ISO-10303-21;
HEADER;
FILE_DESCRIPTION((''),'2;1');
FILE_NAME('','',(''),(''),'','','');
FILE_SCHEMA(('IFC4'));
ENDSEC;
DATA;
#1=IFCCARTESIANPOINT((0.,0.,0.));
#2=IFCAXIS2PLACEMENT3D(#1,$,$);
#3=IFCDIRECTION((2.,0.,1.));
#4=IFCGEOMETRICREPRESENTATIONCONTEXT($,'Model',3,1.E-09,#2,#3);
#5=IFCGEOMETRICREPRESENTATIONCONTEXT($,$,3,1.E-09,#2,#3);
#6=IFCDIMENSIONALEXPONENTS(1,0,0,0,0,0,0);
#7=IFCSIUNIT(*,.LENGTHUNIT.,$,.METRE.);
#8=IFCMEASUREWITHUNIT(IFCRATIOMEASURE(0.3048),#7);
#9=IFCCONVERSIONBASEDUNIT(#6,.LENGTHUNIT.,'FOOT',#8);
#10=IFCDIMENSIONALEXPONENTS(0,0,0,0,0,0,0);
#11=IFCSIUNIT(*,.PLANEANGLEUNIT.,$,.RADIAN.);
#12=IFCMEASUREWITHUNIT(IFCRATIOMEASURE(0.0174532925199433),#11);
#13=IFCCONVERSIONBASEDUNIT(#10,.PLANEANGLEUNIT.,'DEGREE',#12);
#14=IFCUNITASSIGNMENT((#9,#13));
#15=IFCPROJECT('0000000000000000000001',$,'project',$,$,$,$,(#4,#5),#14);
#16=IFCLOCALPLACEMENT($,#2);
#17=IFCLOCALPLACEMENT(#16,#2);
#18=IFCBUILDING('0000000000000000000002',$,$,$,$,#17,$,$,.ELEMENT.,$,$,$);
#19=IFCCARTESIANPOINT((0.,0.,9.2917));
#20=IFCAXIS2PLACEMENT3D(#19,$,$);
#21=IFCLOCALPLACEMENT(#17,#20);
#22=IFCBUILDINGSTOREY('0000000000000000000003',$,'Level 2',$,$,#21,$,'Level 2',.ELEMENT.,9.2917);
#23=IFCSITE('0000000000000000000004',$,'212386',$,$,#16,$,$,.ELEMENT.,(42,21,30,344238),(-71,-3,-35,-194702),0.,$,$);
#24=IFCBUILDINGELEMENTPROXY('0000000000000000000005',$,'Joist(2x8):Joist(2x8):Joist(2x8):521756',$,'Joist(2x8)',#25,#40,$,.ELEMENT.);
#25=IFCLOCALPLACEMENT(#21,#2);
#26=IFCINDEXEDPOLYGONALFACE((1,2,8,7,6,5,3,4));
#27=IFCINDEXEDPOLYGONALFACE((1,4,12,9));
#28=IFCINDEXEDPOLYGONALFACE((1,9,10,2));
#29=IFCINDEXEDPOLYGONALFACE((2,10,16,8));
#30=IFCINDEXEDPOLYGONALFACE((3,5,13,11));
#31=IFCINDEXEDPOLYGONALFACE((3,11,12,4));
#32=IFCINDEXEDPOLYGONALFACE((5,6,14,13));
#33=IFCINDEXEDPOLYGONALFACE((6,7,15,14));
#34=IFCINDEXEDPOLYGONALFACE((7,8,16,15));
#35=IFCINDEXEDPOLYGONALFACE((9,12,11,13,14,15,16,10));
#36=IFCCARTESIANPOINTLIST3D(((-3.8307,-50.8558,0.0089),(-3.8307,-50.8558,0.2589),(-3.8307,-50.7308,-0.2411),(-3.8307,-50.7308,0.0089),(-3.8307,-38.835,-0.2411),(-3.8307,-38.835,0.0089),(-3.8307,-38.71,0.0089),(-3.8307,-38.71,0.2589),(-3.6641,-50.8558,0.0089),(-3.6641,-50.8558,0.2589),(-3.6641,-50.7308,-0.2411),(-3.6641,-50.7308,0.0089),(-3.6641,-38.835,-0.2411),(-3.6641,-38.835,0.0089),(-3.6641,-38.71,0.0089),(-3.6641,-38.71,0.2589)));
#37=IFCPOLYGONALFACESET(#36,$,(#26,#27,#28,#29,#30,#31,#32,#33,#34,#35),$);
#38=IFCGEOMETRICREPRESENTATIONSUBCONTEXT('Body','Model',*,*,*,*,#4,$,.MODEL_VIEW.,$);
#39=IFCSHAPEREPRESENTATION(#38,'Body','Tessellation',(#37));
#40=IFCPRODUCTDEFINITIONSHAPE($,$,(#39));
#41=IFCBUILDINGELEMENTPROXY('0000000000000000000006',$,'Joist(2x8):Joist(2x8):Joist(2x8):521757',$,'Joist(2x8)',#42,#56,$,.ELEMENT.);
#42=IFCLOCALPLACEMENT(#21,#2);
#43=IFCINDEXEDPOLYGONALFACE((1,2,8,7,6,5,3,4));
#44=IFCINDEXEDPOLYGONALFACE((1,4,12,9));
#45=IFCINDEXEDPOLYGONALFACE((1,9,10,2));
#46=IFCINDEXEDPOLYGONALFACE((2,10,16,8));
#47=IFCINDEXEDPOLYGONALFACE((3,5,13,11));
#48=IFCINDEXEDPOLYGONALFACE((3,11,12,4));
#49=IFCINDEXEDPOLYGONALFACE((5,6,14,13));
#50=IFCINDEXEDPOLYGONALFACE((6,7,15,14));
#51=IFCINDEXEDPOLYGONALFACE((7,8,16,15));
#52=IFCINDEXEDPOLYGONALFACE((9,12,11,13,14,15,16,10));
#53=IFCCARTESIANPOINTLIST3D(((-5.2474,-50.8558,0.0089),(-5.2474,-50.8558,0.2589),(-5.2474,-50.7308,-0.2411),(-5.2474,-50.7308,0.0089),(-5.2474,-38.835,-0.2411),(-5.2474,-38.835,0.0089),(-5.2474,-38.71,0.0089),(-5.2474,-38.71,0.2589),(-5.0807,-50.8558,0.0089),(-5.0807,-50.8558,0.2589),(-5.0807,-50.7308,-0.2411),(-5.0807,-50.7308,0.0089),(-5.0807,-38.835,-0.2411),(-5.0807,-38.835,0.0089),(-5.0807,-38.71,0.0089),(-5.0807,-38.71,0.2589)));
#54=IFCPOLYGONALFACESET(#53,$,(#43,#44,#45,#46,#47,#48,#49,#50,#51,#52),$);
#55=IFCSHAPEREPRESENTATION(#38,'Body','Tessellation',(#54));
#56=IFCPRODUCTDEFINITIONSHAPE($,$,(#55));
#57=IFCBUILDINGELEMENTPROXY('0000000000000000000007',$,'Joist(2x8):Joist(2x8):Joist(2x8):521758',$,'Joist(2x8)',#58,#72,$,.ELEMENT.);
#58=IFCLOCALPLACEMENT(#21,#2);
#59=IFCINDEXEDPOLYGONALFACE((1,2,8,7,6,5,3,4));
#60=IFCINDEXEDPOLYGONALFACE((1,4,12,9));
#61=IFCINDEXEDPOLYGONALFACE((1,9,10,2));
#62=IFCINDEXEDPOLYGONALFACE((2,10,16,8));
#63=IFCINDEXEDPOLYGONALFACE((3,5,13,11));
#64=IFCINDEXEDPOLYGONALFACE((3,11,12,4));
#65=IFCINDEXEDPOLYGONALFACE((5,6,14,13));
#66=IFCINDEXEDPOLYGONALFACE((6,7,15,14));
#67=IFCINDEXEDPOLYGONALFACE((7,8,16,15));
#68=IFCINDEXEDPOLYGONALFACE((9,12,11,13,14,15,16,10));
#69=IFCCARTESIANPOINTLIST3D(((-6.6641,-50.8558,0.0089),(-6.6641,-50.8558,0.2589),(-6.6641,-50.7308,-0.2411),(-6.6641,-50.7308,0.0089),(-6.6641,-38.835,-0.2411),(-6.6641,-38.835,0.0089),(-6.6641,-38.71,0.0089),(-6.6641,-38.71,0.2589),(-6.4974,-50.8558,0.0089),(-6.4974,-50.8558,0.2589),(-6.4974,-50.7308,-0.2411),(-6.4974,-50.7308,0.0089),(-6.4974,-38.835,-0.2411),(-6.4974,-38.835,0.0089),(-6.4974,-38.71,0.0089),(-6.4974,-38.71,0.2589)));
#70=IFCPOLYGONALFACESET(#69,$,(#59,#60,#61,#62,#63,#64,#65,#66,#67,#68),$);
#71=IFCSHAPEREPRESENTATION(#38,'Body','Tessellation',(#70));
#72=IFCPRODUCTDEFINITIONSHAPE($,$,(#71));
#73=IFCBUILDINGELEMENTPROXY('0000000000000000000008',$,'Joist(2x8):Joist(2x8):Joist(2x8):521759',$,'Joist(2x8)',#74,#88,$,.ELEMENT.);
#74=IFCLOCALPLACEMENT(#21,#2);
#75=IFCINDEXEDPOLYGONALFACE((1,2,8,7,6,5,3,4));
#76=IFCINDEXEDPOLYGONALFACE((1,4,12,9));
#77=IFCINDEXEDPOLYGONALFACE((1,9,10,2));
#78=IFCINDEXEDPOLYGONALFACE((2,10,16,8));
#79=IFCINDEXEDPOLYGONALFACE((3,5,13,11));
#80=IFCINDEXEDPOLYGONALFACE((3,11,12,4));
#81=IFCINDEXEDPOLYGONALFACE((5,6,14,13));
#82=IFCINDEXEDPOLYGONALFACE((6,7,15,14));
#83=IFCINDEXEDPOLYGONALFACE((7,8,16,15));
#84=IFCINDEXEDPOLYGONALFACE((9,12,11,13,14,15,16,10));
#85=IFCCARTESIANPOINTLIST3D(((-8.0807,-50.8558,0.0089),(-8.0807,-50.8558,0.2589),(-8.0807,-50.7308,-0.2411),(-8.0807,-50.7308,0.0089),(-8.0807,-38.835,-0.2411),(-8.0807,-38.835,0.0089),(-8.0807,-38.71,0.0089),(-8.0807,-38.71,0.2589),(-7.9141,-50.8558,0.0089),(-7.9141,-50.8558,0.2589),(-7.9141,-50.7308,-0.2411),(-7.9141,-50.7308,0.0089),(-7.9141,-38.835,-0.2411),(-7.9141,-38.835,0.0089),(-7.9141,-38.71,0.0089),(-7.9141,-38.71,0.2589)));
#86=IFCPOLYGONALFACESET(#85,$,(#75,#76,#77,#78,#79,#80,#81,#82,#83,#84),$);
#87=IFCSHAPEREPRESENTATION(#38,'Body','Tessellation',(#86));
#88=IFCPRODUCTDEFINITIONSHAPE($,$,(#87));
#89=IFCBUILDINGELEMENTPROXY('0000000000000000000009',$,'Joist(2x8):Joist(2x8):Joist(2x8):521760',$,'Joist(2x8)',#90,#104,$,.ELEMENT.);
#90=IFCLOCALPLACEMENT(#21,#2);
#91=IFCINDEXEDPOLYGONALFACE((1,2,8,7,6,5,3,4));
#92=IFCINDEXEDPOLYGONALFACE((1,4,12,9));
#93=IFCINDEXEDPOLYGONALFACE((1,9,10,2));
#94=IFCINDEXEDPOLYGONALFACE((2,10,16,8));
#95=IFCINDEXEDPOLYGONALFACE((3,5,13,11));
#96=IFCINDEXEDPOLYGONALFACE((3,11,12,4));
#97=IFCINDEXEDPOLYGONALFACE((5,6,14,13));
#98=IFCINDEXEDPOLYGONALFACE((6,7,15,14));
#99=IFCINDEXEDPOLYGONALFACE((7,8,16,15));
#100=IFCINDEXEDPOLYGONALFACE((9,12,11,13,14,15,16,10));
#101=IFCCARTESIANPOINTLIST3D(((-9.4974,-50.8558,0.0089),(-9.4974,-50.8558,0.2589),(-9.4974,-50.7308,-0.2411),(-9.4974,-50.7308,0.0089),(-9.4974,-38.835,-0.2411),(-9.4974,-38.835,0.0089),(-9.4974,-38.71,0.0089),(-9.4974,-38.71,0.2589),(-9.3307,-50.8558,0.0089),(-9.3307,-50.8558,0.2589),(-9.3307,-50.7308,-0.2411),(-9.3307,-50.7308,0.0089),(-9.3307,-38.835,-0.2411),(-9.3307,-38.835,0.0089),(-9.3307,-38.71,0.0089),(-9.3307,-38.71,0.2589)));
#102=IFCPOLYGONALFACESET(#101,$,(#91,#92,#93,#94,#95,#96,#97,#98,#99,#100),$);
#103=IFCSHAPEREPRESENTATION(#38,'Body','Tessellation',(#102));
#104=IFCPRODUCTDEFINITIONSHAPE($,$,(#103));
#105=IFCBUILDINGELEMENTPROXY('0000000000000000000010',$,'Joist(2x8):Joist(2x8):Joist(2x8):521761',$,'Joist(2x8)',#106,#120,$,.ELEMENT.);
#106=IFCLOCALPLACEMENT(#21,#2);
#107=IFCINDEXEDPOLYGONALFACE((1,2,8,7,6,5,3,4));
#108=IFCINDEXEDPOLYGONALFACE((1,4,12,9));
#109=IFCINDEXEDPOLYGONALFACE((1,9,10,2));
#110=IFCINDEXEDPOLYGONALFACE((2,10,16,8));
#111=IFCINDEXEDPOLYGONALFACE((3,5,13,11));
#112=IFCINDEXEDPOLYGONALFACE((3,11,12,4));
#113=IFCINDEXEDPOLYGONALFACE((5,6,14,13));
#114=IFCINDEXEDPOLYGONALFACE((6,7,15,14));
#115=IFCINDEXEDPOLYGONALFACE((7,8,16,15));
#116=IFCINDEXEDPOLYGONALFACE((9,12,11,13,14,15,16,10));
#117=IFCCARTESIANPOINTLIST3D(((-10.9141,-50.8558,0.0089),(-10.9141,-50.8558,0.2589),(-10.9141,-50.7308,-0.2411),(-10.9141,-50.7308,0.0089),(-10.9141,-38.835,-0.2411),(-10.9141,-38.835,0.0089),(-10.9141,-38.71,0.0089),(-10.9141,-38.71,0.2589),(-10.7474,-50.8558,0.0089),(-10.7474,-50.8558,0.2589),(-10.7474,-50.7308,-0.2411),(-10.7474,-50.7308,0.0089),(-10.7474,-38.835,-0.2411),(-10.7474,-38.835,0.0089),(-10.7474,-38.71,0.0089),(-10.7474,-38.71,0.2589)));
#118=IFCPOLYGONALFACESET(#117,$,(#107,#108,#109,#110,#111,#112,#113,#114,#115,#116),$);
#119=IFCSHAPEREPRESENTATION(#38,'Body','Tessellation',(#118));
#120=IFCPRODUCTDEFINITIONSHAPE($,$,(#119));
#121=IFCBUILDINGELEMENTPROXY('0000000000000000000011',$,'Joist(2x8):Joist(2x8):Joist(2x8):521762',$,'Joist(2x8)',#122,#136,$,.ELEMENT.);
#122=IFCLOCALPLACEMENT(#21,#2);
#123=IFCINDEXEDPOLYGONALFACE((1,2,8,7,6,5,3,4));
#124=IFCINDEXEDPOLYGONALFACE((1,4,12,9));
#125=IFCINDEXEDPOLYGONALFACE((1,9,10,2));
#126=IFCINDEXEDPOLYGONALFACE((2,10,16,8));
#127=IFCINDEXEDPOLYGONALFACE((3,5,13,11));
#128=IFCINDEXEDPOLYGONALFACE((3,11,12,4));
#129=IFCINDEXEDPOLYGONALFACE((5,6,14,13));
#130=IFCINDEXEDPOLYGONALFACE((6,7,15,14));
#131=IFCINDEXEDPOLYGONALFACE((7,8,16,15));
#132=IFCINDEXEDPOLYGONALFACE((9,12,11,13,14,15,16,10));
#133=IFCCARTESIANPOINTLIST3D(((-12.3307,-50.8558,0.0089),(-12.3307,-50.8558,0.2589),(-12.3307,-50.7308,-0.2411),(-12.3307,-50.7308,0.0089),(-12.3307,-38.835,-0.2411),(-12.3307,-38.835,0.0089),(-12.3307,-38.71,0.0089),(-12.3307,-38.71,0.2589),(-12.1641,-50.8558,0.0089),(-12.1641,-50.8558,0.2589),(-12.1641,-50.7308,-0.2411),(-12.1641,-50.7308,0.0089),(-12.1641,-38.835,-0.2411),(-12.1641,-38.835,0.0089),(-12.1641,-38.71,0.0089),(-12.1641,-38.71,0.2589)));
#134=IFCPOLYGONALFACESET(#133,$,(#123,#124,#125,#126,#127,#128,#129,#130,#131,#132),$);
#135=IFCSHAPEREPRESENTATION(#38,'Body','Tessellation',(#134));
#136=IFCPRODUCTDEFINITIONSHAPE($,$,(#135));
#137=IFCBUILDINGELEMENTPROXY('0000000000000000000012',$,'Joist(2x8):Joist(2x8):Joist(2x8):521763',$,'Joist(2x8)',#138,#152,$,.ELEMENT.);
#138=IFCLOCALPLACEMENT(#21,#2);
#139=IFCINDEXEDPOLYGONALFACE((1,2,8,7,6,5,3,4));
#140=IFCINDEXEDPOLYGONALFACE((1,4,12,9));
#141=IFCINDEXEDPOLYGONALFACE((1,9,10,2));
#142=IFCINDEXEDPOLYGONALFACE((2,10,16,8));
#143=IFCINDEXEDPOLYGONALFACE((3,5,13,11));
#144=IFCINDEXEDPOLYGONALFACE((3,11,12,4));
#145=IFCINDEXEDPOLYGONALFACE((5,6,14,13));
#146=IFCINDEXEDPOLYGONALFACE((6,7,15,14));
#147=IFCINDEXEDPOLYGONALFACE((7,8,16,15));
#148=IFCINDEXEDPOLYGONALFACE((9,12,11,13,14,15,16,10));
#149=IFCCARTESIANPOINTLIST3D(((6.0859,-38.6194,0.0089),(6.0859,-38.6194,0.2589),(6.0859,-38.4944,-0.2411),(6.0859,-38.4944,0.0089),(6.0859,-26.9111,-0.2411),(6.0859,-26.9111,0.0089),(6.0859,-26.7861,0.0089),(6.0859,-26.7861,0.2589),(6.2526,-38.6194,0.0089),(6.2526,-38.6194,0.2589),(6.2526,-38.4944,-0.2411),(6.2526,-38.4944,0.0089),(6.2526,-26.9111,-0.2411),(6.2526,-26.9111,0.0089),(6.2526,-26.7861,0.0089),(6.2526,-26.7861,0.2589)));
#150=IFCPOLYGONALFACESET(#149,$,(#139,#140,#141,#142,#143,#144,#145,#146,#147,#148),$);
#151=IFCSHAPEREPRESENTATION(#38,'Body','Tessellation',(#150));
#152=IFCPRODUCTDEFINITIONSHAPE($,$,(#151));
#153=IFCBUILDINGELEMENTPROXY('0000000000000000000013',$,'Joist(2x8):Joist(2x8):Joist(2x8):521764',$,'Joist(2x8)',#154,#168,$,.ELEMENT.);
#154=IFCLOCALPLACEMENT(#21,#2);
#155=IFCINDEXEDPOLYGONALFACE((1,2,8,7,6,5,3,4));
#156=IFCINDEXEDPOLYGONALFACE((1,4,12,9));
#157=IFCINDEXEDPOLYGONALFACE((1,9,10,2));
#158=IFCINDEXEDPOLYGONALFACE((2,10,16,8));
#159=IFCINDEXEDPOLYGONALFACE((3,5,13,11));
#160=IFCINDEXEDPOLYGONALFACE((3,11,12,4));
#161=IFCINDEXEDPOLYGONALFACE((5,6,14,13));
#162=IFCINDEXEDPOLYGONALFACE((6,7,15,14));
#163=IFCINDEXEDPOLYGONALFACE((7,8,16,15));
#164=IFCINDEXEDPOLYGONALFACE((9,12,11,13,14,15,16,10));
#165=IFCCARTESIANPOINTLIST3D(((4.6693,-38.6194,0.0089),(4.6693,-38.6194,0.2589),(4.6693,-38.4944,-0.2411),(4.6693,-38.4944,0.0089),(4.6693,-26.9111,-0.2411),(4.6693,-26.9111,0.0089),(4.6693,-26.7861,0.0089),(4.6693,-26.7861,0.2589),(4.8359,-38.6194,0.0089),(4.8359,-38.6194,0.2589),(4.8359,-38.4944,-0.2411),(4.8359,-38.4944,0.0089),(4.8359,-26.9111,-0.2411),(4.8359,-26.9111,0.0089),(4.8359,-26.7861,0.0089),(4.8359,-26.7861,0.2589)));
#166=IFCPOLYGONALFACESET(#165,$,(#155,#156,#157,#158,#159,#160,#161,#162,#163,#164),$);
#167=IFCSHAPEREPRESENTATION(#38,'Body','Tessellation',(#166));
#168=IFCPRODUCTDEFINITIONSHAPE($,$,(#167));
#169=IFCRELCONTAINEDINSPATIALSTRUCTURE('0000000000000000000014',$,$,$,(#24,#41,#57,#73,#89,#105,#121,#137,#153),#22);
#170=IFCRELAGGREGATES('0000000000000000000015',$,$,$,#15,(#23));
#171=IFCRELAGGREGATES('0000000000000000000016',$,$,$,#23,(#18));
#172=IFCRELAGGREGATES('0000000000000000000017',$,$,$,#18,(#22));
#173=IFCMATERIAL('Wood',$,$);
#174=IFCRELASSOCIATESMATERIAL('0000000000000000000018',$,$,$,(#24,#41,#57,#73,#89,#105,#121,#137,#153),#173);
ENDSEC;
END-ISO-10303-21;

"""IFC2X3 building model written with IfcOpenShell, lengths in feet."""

from ifc_helpers import new_model, entity, si_unit, converted_unit, direction, frame, origin, place, context, subcontext, project, spatial, polyline, outline, extrude, source, transform, mapped, material, element, save


model = new_model("IFC2X3")

# Units and contexts
model_context = context("Model", 3, precision=1e-09, world=origin(), true_north=direction((2.0, 0.0, 1.0)))
context_of_model = context(None, 3, precision=1e-09, world=origin(), true_north=direction((2.0, 0.0, 1.0)))
body_context = subcontext(model_context, "Body", "Model", "MODEL_VIEW")
ifc_project = project(units=[converted_unit("LENGTHUNIT", "FOOT", entity("IfcRatioMeasure", 0.3048), si_unit("LENGTHUNIT", "METRE"), dimensions=[1, 0, 0, 0, 0, 0, 0]), converted_unit("PLANEANGLEUNIT", "DEGREE", entity("IfcRatioMeasure", 0.0174532925199433), si_unit("PLANEANGLEUNIT", "RADIAN"), dimensions=[0, 0, 0, 0, 0, 0, 0])], contexts=[model_context, context_of_model])

# Site, building, storey
site_placement = place(None, origin())
site = spatial("IfcSite", under=ifc_project, at=site_placement, Name="212386", CompositionType="ELEMENT", RefLatitude=(42, 21, 30, 344238), RefLongitude=(-71, -3, -35, -194702), RefElevation=0.0)
building_placement = place(site_placement, origin())
building = spatial("IfcBuilding", under=site, at=building_placement, CompositionType="ELEMENT")
storey_placement = place(building_placement, frame((0.0, 0.0, 9.2917)))
storey = spatial("IfcBuildingStorey", under=building, at=storey_placement, Name="Level 2", LongName="Level 2", CompositionType="ELEMENT", Elevation=9.2917)

# Building element proxies
ifc_material = material(Name="Wood")
shared_shape_1 = source(origin(), body_context, "Body", "SweptSolid", [
    extrude(outline(polyline([(-0.25, -6.0729), (0.0, -6.0729), (0.0, -5.9479), (0.25, -5.9479), (0.25, 5.9479), (0.0, 5.9479), (0.0, 6.0729), (-0.25, 6.0729), (-0.25, -6.0729)])), frame((-3.8307, -44.7829, 9.3006), z_axis=(1.0, 0.0, 0.0), x_axis=(0.0, 0.0, -1.0)), (0.0, 0.0, 1.0), 0.1667),
])
proxy_1_placement = place(storey_placement, frame((0.0, 0.0, -9.2917)))
element("IfcBuildingElementProxy", 1, at=proxy_1_placement, inside=storey, material=ifc_material, Name="Joist(2x8):Joist(2x8):Joist(2x8):521756", ObjectType="Joist(2x8)", CompositionType="ELEMENT", context=body_context, shape_type="MappedRepresentation", body=[
    mapped(shared_shape_1, transform((0.0, 0.0, 0.0), scale=1.0)),
])
shared_shape_2 = source(origin(), body_context, "Body", "SweptSolid", [
    extrude(outline(polyline([(-0.25, -6.0729), (0.0, -6.0729), (0.0, -5.9479), (0.25, -5.9479), (0.25, 5.9479), (0.0, 5.9479), (0.0, 6.0729), (-0.25, 6.0729), (-0.25, -6.0729)])), frame((-5.2474, -44.7829, 9.3006), z_axis=(1.0, 0.0, 0.0), x_axis=(0.0, 0.0, -1.0)), (0.0, 0.0, 1.0), 0.1667),
])
proxy_2_placement = place(storey_placement, frame((0.0, 0.0, -9.2917)))
element("IfcBuildingElementProxy", 2, at=proxy_2_placement, inside=storey, material=ifc_material, Name="Joist(2x8):Joist(2x8):Joist(2x8):521757", ObjectType="Joist(2x8)", CompositionType="ELEMENT", context=body_context, shape_type="MappedRepresentation", body=[
    mapped(shared_shape_2, transform((0.0, 0.0, 0.0), scale=1.0)),
])
shared_shape_3 = source(origin(), body_context, "Body", "SweptSolid", [
    extrude(outline(polyline([(-0.25, -6.0729), (0.0, -6.0729), (0.0, -5.9479), (0.25, -5.9479), (0.25, 5.9479), (0.0, 5.9479), (0.0, 6.0729), (-0.25, 6.0729), (-0.25, -6.0729)])), frame((-6.6641, -44.7829, 9.3006), z_axis=(1.0, 0.0, 0.0), x_axis=(0.0, 0.0, -1.0)), (0.0, 0.0, 1.0), 0.1667),
])
proxy_3_placement = place(storey_placement, frame((0.0, 0.0, -9.2917)))
element("IfcBuildingElementProxy", 3, at=proxy_3_placement, inside=storey, material=ifc_material, Name="Joist(2x8):Joist(2x8):Joist(2x8):521758", ObjectType="Joist(2x8)", CompositionType="ELEMENT", context=body_context, shape_type="MappedRepresentation", body=[
    mapped(shared_shape_3, transform((0.0, 0.0, 0.0), scale=1.0)),
])
shared_shape_4 = source(origin(), body_context, "Body", "SweptSolid", [
    extrude(outline(polyline([(-0.25, -6.0729), (0.0, -6.0729), (0.0, -5.9479), (0.25, -5.9479), (0.25, 5.9479), (0.0, 5.9479), (0.0, 6.0729), (-0.25, 6.0729), (-0.25, -6.0729)])), frame((-8.0807, -44.7829, 9.3006), z_axis=(1.0, 0.0, 0.0), x_axis=(0.0, 0.0, -1.0)), (0.0, 0.0, 1.0), 0.1667),
])
proxy_4_placement = place(storey_placement, frame((0.0, 0.0, -9.2917)))
element("IfcBuildingElementProxy", 4, at=proxy_4_placement, inside=storey, material=ifc_material, Name="Joist(2x8):Joist(2x8):Joist(2x8):521759", ObjectType="Joist(2x8)", CompositionType="ELEMENT", context=body_context, shape_type="MappedRepresentation", body=[
    mapped(shared_shape_4, transform((0.0, 0.0, 0.0), scale=1.0)),
])
shared_shape_5 = source(origin(), body_context, "Body", "SweptSolid", [
    extrude(outline(polyline([(-0.25, -6.0729), (0.0, -6.0729), (0.0, -5.9479), (0.25, -5.9479), (0.25, 5.9479), (0.0, 5.9479), (0.0, 6.0729), (-0.25, 6.0729), (-0.25, -6.0729)])), frame((-9.4974, -44.7829, 9.3006), z_axis=(1.0, 0.0, 0.0), x_axis=(0.0, 0.0, -1.0)), (0.0, 0.0, 1.0), 0.1667),
])
proxy_5_placement = place(storey_placement, frame((0.0, 0.0, -9.2917)))
element("IfcBuildingElementProxy", 5, at=proxy_5_placement, inside=storey, material=ifc_material, Name="Joist(2x8):Joist(2x8):Joist(2x8):521760", ObjectType="Joist(2x8)", CompositionType="ELEMENT", context=body_context, shape_type="MappedRepresentation", body=[
    mapped(shared_shape_5, transform((0.0, 0.0, 0.0), scale=1.0)),
])
shared_shape_6 = source(origin(), body_context, "Body", "SweptSolid", [
    extrude(outline(polyline([(-0.25, -6.0729), (0.0, -6.0729), (0.0, -5.9479), (0.25, -5.9479), (0.25, 5.9479), (0.0, 5.9479), (0.0, 6.0729), (-0.25, 6.0729), (-0.25, -6.0729)])), frame((-10.9141, -44.7829, 9.3006), z_axis=(1.0, 0.0, 0.0), x_axis=(0.0, 0.0, -1.0)), (0.0, 0.0, 1.0), 0.1667),
])
proxy_6_placement = place(storey_placement, frame((0.0, 0.0, -9.2917)))
element("IfcBuildingElementProxy", 6, at=proxy_6_placement, inside=storey, material=ifc_material, Name="Joist(2x8):Joist(2x8):Joist(2x8):521761", ObjectType="Joist(2x8)", CompositionType="ELEMENT", context=body_context, shape_type="MappedRepresentation", body=[
    mapped(shared_shape_6, transform((0.0, 0.0, 0.0), scale=1.0)),
])
shared_shape_7 = source(origin(), body_context, "Body", "SweptSolid", [
    extrude(outline(polyline([(-0.25, -6.0729), (0.0, -6.0729), (0.0, -5.9479), (0.25, -5.9479), (0.25, 5.9479), (0.0, 5.9479), (0.0, 6.0729), (-0.25, 6.0729), (-0.25, -6.0729)])), frame((-12.3307, -44.7829, 9.3006), z_axis=(1.0, 0.0, 0.0), x_axis=(0.0, 0.0, -1.0)), (0.0, 0.0, 1.0), 0.1667),
])
proxy_7_placement = place(storey_placement, frame((0.0, 0.0, -9.2917)))
element("IfcBuildingElementProxy", 7, at=proxy_7_placement, inside=storey, material=ifc_material, Name="Joist(2x8):Joist(2x8):Joist(2x8):521762", ObjectType="Joist(2x8)", CompositionType="ELEMENT", context=body_context, shape_type="MappedRepresentation", body=[
    mapped(shared_shape_7, transform((0.0, 0.0, 0.0), scale=1.0)),
])
shared_shape_8 = source(origin(), body_context, "Body", "SweptSolid", [
    extrude(outline(polyline([(-0.25, -5.9167), (0.0, -5.9167), (0.0, -5.7917), (0.25, -5.7917), (0.25, 5.7917), (0.0, 5.7917), (0.0, 5.9167), (-0.25, 5.9167), (-0.25, -5.9167)])), frame((6.0859, -32.7027, 9.3006), z_axis=(1.0, 0.0, 0.0), x_axis=(0.0, 0.0, -1.0)), (0.0, 0.0, 1.0), 0.1667),
])
proxy_8_placement = place(storey_placement, frame((0.0, 0.0, -9.2917)))
element("IfcBuildingElementProxy", 8, at=proxy_8_placement, inside=storey, material=ifc_material, Name="Joist(2x8):Joist(2x8):Joist(2x8):521763", ObjectType="Joist(2x8)", CompositionType="ELEMENT", context=body_context, shape_type="MappedRepresentation", body=[
    mapped(shared_shape_8, transform((0.0, 0.0, 0.0), scale=1.0)),
])
shared_shape_9 = source(origin(), body_context, "Body", "SweptSolid", [
    extrude(outline(polyline([(-0.25, -5.9167), (0.0, -5.9167), (0.0, -5.7917), (0.25, -5.7917), (0.25, 5.7917), (0.0, 5.7917), (0.0, 5.9167), (-0.25, 5.9167), (-0.25, -5.9167)])), frame((4.6693, -32.7027, 9.3006), z_axis=(1.0, 0.0, 0.0), x_axis=(0.0, 0.0, -1.0)), (0.0, 0.0, 1.0), 0.1667),
])
proxy_9_placement = place(storey_placement, frame((0.0, 0.0, -9.2917)))
element("IfcBuildingElementProxy", 9, at=proxy_9_placement, inside=storey, material=ifc_material, Name="Joist(2x8):Joist(2x8):Joist(2x8):521764", ObjectType="Joist(2x8)", CompositionType="ELEMENT", context=body_context, shape_type="MappedRepresentation", body=[
    mapped(shared_shape_9, transform((0.0, 0.0, 0.0), scale=1.0)),
])

save(model, "model.ifc")
